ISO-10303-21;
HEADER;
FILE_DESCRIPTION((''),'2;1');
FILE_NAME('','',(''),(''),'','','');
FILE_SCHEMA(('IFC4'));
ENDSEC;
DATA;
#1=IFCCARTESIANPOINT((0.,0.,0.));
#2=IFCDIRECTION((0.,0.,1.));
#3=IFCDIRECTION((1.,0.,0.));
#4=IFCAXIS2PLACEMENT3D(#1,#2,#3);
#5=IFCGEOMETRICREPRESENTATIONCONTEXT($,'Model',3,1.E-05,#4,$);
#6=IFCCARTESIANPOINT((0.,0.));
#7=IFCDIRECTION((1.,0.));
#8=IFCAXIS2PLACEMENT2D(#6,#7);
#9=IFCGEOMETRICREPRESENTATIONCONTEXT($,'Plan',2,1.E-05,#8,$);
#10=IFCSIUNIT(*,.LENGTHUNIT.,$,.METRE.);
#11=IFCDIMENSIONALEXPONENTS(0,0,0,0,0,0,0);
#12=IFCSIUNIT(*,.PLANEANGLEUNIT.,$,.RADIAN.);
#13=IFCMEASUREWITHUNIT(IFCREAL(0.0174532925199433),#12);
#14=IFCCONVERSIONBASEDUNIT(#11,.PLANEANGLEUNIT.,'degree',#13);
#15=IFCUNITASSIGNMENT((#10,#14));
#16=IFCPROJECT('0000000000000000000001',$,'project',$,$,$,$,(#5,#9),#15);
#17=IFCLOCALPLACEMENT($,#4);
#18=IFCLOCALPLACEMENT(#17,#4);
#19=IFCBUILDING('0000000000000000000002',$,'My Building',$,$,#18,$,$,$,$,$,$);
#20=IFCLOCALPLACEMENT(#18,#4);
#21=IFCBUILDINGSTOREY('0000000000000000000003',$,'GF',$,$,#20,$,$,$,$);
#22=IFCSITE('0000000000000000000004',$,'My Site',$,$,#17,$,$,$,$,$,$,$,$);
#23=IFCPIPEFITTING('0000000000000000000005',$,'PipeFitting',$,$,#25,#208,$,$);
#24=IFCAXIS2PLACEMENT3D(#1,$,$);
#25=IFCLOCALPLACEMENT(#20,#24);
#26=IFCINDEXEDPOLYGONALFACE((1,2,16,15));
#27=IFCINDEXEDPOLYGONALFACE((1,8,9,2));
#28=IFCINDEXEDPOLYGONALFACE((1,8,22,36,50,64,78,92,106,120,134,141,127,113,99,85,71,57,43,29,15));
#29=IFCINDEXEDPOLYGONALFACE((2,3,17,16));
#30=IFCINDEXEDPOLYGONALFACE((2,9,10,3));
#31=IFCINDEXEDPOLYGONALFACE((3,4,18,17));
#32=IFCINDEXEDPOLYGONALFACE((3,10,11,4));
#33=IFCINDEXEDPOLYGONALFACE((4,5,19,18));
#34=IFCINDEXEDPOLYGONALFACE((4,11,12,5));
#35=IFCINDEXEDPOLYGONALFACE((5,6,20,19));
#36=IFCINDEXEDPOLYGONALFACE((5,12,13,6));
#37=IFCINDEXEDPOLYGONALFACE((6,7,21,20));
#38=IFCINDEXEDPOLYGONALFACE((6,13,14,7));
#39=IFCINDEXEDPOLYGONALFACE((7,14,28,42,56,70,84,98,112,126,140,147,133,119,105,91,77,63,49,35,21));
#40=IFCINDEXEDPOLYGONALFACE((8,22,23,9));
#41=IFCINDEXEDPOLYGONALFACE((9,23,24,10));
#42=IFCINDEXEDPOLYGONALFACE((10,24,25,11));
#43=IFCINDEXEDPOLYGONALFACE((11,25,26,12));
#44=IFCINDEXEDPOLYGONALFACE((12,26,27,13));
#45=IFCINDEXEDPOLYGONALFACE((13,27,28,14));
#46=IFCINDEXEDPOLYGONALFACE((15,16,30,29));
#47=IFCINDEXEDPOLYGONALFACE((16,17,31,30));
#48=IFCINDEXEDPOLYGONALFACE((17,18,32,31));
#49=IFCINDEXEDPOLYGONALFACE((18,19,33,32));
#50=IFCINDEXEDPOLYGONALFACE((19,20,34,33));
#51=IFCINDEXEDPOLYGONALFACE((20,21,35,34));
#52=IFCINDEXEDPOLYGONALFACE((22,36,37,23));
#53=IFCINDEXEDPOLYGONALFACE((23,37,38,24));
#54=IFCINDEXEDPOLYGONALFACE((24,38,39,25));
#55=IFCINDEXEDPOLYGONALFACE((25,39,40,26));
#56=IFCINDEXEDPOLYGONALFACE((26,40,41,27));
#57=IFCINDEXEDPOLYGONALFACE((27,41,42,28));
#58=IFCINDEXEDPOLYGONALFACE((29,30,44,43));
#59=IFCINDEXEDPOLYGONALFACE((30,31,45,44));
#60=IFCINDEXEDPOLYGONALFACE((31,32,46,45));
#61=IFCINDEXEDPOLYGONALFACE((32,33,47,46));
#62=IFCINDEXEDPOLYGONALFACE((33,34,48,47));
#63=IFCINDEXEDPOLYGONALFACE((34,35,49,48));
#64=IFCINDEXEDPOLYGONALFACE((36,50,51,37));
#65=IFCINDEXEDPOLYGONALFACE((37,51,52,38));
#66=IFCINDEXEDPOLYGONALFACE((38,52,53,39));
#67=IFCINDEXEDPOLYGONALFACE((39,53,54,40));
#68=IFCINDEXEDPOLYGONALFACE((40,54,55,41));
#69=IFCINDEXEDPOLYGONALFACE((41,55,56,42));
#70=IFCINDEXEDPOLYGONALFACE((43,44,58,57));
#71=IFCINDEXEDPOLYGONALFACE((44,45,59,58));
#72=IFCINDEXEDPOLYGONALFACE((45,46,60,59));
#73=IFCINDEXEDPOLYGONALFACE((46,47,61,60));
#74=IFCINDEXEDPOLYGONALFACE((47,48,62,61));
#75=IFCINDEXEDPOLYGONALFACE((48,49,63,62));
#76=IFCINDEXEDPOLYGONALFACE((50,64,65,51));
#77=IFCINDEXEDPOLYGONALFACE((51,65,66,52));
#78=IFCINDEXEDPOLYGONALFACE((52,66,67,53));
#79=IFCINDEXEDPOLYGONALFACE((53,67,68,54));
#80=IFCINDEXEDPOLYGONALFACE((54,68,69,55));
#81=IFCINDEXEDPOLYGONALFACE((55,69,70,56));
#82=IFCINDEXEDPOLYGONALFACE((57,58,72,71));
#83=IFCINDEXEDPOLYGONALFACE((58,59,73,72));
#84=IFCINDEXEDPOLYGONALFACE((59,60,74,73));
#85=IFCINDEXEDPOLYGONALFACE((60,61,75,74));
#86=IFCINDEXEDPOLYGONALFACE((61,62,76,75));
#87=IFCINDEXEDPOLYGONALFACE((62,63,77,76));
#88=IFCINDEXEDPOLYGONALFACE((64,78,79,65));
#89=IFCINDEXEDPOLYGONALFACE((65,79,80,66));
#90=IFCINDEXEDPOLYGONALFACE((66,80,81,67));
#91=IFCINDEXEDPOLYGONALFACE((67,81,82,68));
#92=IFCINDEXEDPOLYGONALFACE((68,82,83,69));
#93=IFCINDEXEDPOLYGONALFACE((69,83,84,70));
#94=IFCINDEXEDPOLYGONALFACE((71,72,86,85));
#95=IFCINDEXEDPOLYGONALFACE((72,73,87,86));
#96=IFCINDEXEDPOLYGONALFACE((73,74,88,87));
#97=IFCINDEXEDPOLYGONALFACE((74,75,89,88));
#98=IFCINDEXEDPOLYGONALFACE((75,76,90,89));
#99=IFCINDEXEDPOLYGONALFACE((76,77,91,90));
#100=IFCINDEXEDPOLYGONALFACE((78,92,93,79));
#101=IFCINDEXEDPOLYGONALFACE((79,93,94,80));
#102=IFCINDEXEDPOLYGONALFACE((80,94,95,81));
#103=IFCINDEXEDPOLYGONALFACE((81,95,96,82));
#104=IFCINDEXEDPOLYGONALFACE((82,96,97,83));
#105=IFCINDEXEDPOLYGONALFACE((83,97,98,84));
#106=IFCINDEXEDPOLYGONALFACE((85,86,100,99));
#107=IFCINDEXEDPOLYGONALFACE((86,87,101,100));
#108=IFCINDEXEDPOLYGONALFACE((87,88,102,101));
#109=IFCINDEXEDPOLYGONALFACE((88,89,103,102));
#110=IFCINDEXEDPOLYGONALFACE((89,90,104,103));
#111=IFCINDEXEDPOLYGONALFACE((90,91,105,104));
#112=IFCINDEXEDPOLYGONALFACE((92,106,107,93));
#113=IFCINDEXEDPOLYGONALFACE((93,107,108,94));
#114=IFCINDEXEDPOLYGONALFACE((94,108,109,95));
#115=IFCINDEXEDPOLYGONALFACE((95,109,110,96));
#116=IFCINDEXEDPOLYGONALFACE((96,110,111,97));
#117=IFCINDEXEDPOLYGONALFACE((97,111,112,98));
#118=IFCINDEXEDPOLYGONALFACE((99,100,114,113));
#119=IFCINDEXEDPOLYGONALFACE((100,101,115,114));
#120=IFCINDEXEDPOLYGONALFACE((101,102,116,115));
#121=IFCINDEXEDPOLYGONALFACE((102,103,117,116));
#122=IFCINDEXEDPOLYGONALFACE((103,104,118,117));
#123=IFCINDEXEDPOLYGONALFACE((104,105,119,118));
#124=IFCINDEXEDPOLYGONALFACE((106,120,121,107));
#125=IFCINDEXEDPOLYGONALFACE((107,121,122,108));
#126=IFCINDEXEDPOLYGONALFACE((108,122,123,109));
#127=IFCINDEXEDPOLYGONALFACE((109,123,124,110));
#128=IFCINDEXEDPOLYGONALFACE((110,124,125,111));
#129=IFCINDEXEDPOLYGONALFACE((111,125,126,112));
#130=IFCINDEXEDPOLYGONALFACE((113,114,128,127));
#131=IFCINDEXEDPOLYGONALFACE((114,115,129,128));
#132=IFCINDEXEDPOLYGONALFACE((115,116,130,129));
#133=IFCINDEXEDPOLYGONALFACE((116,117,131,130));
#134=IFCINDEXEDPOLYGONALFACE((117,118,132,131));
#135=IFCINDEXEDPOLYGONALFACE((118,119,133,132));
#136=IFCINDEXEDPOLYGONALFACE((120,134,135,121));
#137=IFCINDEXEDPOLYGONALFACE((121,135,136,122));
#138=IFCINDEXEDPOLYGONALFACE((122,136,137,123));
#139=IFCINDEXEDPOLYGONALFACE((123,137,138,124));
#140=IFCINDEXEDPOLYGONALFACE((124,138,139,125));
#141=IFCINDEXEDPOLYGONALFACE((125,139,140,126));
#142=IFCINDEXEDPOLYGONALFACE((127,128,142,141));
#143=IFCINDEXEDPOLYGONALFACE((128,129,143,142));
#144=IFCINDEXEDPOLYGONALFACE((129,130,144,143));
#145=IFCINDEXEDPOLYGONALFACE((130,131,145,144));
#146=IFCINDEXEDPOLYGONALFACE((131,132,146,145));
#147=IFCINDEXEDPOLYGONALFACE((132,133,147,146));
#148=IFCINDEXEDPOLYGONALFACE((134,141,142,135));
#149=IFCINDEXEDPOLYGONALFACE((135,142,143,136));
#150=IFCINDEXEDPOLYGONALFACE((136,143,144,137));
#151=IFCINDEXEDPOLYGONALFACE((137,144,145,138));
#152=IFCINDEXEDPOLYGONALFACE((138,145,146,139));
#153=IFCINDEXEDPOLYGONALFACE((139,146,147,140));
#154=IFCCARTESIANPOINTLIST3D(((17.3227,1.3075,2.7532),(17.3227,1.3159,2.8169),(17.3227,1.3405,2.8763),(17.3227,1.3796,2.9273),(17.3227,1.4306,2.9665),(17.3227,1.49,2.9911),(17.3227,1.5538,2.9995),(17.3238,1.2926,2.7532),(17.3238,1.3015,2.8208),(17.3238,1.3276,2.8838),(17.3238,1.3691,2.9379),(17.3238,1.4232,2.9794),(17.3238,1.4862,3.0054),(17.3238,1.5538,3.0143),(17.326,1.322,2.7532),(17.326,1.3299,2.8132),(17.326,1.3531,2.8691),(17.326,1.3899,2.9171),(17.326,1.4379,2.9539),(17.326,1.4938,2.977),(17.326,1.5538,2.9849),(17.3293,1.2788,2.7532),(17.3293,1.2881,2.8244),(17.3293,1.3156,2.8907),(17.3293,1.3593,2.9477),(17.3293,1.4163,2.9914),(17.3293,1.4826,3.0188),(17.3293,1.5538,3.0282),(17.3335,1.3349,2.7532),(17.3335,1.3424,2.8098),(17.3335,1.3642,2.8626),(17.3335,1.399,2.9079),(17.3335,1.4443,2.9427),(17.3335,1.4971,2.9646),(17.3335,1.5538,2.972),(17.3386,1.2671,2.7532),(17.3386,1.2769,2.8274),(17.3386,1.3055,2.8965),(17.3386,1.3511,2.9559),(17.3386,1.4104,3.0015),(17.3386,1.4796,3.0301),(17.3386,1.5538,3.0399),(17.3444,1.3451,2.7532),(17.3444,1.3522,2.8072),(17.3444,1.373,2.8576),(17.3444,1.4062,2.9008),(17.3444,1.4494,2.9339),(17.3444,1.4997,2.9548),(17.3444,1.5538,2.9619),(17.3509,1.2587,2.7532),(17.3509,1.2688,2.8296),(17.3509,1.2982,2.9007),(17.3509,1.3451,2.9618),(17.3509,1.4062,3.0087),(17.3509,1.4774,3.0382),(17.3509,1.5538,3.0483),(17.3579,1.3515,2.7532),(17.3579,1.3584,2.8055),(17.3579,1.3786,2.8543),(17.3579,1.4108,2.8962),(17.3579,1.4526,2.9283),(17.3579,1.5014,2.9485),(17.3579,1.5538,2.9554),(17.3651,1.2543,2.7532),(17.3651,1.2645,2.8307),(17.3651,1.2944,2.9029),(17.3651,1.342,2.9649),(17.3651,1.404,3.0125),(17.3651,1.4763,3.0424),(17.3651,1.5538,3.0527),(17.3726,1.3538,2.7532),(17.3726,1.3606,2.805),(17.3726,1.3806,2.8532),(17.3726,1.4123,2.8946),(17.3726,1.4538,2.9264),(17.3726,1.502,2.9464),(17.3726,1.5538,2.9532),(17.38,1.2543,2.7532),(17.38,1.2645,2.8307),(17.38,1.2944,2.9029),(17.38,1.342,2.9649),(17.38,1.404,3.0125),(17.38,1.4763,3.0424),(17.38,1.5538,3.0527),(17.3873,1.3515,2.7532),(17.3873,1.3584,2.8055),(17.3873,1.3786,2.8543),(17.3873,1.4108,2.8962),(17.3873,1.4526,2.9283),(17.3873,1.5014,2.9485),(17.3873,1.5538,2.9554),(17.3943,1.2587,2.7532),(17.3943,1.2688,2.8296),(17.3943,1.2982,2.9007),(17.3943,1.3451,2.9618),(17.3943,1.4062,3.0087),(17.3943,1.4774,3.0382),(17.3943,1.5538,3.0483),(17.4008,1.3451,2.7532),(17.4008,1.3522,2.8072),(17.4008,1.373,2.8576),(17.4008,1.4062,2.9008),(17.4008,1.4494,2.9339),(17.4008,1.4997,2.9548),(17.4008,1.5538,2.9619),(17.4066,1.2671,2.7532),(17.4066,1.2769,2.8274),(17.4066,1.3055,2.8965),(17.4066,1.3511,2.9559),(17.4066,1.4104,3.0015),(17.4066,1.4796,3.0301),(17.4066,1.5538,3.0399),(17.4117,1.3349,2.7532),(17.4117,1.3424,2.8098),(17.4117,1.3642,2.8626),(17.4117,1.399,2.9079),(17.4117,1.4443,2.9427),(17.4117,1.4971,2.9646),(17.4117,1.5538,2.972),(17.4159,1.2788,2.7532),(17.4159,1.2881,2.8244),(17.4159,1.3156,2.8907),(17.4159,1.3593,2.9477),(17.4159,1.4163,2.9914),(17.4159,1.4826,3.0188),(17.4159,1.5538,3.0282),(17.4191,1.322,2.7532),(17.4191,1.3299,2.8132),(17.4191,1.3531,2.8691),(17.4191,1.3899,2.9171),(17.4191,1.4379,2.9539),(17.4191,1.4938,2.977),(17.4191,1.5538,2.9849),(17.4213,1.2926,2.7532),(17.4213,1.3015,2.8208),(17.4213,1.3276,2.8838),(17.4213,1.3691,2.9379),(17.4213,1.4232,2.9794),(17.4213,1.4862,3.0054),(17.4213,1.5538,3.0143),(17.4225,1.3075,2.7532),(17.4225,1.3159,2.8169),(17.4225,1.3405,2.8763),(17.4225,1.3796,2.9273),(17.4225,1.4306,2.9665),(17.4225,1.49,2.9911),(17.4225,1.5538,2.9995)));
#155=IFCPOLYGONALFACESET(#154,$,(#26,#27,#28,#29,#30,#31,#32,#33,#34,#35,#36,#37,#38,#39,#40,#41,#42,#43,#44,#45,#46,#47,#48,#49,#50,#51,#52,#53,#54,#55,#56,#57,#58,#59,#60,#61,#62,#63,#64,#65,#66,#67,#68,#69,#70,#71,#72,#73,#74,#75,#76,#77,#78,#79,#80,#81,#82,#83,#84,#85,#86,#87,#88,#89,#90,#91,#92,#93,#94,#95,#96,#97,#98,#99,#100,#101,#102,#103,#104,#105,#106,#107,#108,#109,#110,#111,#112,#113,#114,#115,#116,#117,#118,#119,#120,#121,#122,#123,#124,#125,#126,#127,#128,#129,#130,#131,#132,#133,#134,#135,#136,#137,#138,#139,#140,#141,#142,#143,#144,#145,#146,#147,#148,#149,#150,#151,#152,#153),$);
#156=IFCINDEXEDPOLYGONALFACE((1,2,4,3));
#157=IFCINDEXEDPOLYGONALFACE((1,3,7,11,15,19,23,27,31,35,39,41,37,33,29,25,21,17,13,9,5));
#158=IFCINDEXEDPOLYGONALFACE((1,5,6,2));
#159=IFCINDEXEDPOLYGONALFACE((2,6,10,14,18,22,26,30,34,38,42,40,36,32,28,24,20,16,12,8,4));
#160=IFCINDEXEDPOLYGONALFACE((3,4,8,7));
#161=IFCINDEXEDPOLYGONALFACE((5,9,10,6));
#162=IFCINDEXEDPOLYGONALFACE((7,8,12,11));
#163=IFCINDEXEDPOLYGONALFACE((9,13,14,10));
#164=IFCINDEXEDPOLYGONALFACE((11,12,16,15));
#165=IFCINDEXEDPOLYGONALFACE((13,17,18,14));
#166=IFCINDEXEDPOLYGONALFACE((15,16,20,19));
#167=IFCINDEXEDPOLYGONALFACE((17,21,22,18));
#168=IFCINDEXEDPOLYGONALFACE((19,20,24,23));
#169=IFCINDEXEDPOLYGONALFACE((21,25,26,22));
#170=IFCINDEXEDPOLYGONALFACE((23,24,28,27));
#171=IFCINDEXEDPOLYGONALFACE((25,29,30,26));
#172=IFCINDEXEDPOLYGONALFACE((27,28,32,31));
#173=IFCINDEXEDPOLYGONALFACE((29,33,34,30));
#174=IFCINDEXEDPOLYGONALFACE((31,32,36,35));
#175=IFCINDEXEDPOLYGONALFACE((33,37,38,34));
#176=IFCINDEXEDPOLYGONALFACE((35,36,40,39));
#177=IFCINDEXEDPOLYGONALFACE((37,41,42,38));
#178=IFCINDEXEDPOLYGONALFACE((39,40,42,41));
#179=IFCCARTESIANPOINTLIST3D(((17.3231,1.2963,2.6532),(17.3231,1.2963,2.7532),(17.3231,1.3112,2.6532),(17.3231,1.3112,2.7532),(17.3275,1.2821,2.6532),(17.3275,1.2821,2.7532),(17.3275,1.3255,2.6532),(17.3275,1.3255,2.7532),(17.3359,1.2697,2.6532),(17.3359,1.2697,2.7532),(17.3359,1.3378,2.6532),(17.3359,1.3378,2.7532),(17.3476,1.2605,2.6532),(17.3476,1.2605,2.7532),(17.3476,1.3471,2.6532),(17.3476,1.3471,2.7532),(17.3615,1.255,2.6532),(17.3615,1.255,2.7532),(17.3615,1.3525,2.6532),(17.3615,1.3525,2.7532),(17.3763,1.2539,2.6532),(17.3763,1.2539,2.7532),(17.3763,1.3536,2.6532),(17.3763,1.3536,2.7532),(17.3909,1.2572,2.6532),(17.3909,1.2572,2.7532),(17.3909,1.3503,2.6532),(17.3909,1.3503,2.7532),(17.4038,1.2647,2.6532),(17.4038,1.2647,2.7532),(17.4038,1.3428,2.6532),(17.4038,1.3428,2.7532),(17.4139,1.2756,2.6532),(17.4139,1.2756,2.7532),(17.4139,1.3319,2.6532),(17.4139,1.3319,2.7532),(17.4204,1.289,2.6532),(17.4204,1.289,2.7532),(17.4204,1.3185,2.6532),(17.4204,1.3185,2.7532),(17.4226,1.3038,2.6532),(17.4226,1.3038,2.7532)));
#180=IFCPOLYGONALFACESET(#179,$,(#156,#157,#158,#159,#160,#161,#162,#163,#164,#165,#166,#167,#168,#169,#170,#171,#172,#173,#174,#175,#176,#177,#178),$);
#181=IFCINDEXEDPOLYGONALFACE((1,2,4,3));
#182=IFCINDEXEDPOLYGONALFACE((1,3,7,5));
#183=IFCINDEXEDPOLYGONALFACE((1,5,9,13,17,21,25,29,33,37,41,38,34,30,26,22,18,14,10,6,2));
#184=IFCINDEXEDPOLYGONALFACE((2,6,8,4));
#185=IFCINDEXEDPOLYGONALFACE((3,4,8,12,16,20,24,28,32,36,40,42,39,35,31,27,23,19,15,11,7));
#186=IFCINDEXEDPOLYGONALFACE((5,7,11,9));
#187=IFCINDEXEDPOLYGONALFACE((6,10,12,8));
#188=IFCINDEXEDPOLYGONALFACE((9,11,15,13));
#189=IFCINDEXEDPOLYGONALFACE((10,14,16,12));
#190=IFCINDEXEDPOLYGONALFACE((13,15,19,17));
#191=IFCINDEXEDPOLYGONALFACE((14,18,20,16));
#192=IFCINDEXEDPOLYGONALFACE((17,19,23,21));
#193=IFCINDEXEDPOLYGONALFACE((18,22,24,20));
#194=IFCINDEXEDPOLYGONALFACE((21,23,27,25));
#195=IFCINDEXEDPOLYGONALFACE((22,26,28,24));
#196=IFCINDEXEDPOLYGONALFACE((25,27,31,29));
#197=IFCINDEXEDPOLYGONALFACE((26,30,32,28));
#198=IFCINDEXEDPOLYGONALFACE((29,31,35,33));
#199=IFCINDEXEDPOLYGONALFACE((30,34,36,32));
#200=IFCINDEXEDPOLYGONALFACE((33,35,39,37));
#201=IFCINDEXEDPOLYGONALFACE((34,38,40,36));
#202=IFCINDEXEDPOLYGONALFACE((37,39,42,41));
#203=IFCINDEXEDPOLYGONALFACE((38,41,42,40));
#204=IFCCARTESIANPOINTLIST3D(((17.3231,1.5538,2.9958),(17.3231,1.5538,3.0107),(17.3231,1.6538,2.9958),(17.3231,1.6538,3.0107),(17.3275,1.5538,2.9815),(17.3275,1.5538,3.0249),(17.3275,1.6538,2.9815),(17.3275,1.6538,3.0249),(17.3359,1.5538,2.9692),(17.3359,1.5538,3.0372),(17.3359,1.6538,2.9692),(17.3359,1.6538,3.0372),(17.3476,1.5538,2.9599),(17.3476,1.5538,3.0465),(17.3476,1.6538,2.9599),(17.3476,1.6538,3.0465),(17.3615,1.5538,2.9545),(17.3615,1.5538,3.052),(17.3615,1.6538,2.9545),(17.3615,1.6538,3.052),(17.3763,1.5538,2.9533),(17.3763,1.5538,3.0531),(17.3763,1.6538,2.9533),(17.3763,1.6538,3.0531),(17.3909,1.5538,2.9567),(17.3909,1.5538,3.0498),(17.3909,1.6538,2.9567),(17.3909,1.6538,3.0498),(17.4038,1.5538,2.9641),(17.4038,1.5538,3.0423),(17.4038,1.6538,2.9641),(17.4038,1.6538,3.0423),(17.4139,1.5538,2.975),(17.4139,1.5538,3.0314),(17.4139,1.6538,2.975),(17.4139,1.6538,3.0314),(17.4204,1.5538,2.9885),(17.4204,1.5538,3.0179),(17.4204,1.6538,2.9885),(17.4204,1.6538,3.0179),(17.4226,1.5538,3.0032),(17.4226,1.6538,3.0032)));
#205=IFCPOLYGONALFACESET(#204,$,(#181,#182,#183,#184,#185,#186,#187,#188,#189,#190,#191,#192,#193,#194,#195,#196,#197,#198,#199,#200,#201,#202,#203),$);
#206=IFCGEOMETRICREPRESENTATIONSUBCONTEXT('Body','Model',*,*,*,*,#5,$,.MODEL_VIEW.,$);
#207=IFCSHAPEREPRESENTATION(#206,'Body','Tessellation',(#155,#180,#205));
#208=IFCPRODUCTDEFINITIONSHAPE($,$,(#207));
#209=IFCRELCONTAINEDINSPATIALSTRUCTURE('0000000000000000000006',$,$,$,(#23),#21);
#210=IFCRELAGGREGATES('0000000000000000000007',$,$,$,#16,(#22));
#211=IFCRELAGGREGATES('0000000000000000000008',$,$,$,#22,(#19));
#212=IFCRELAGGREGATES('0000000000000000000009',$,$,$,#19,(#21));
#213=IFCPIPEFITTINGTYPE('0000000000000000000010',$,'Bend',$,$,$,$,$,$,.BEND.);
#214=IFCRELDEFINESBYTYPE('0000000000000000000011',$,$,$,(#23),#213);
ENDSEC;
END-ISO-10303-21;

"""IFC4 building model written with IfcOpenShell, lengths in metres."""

from ifc_helpers import new_model, entity, si_unit, converted_unit, frame, origin_with_axes, origin_2d_with_axis, place, context, subcontext, project, spatial, circle, extrude, source, transform, mapped, type_object, type_shapes, element, save


model = new_model("IFC4")

# Units and contexts
model_context = context("Model", 3, precision=1e-05, world=origin_with_axes())
plan_context = context("Plan", 2, precision=1e-05, world=origin_2d_with_axis())
body_context_1 = subcontext(model_context, "Body", "Model", "MODEL_VIEW")
ifc_project = project(units=[si_unit("LENGTHUNIT", "METRE"), converted_unit("PLANEANGLEUNIT", "degree", entity("IfcReal", 0.0174532925199433), si_unit("PLANEANGLEUNIT", "RADIAN"), dimensions=[0, 0, 0, 0, 0, 0, 0])], contexts=[model_context, plan_context])

# Site, building, storey
site_placement = place(None, origin_with_axes())
site = spatial("IfcSite", under=ifc_project, at=site_placement, Name="My Site")
building_placement = place(site_placement, origin_with_axes())
building = spatial("IfcBuilding", under=site, at=building_placement, Name="My Building")
storey_placement = place(building_placement, origin_with_axes())
storey = spatial("IfcBuildingStorey", under=building, at=storey_placement, Name="GF")

# Pipe fitting
pipe_fitting_type = type_object("IfcPipeFittingType", Name="Bend", PredefinedType="BEND")
shared_shape_1 = source(origin_with_axes(), body_context_1, "Body", "SolidModel", [
    entity("IfcSweptDiskSolid", entity("IfcIndexedPolyCurve", entity("IfcCartesianPointList3D", [[0.0, 0.0, -0.1], [0.0, -0.0732, -0.2768], [0.0, -0.25, -0.35]]), [entity("IfcArcIndex", [1, 2, 3])]), 0.05),
    extrude(circle(Radius=0.05), origin_with_axes(), (0.0, 0.0, -1.0), 0.1),
    extrude(circle(Radius=0.05), frame((0.0, -0.25, -0.35), z_axis=(0.0, -1.0, 0.0), x_axis=(1.0, 0.0, 0.0)), (0.0, 0.0, 1.0), 0.1),
])
type_shapes(pipe_fitting_type, [shared_shape_1])
for number, where, z_axis, x_axis, name in (
    (1, (17.3726, 1.3038, 2.6532), (0.0, 0.0, -1.0), (1.0, 0.0, 0.0), "PipeFitting"),
):
    element("IfcPipeFitting", number, at=place(storey_placement, frame(where, z_axis=z_axis, x_axis=x_axis)), inside=storey, type_object=pipe_fitting_type, Name=name, context=body_context_1, shape_type="MappedRepresentation", body=[
        mapped(shared_shape_1, transform((0.0, 0.0, 0.0), x_axis=(1.0, 0.0, 0.0), y_axis=(0.0, 1.0, 0.0), z_axis=(0.0, 0.0, 1.0), scale=1.0)),
    ])

save(model, "model.ifc")
